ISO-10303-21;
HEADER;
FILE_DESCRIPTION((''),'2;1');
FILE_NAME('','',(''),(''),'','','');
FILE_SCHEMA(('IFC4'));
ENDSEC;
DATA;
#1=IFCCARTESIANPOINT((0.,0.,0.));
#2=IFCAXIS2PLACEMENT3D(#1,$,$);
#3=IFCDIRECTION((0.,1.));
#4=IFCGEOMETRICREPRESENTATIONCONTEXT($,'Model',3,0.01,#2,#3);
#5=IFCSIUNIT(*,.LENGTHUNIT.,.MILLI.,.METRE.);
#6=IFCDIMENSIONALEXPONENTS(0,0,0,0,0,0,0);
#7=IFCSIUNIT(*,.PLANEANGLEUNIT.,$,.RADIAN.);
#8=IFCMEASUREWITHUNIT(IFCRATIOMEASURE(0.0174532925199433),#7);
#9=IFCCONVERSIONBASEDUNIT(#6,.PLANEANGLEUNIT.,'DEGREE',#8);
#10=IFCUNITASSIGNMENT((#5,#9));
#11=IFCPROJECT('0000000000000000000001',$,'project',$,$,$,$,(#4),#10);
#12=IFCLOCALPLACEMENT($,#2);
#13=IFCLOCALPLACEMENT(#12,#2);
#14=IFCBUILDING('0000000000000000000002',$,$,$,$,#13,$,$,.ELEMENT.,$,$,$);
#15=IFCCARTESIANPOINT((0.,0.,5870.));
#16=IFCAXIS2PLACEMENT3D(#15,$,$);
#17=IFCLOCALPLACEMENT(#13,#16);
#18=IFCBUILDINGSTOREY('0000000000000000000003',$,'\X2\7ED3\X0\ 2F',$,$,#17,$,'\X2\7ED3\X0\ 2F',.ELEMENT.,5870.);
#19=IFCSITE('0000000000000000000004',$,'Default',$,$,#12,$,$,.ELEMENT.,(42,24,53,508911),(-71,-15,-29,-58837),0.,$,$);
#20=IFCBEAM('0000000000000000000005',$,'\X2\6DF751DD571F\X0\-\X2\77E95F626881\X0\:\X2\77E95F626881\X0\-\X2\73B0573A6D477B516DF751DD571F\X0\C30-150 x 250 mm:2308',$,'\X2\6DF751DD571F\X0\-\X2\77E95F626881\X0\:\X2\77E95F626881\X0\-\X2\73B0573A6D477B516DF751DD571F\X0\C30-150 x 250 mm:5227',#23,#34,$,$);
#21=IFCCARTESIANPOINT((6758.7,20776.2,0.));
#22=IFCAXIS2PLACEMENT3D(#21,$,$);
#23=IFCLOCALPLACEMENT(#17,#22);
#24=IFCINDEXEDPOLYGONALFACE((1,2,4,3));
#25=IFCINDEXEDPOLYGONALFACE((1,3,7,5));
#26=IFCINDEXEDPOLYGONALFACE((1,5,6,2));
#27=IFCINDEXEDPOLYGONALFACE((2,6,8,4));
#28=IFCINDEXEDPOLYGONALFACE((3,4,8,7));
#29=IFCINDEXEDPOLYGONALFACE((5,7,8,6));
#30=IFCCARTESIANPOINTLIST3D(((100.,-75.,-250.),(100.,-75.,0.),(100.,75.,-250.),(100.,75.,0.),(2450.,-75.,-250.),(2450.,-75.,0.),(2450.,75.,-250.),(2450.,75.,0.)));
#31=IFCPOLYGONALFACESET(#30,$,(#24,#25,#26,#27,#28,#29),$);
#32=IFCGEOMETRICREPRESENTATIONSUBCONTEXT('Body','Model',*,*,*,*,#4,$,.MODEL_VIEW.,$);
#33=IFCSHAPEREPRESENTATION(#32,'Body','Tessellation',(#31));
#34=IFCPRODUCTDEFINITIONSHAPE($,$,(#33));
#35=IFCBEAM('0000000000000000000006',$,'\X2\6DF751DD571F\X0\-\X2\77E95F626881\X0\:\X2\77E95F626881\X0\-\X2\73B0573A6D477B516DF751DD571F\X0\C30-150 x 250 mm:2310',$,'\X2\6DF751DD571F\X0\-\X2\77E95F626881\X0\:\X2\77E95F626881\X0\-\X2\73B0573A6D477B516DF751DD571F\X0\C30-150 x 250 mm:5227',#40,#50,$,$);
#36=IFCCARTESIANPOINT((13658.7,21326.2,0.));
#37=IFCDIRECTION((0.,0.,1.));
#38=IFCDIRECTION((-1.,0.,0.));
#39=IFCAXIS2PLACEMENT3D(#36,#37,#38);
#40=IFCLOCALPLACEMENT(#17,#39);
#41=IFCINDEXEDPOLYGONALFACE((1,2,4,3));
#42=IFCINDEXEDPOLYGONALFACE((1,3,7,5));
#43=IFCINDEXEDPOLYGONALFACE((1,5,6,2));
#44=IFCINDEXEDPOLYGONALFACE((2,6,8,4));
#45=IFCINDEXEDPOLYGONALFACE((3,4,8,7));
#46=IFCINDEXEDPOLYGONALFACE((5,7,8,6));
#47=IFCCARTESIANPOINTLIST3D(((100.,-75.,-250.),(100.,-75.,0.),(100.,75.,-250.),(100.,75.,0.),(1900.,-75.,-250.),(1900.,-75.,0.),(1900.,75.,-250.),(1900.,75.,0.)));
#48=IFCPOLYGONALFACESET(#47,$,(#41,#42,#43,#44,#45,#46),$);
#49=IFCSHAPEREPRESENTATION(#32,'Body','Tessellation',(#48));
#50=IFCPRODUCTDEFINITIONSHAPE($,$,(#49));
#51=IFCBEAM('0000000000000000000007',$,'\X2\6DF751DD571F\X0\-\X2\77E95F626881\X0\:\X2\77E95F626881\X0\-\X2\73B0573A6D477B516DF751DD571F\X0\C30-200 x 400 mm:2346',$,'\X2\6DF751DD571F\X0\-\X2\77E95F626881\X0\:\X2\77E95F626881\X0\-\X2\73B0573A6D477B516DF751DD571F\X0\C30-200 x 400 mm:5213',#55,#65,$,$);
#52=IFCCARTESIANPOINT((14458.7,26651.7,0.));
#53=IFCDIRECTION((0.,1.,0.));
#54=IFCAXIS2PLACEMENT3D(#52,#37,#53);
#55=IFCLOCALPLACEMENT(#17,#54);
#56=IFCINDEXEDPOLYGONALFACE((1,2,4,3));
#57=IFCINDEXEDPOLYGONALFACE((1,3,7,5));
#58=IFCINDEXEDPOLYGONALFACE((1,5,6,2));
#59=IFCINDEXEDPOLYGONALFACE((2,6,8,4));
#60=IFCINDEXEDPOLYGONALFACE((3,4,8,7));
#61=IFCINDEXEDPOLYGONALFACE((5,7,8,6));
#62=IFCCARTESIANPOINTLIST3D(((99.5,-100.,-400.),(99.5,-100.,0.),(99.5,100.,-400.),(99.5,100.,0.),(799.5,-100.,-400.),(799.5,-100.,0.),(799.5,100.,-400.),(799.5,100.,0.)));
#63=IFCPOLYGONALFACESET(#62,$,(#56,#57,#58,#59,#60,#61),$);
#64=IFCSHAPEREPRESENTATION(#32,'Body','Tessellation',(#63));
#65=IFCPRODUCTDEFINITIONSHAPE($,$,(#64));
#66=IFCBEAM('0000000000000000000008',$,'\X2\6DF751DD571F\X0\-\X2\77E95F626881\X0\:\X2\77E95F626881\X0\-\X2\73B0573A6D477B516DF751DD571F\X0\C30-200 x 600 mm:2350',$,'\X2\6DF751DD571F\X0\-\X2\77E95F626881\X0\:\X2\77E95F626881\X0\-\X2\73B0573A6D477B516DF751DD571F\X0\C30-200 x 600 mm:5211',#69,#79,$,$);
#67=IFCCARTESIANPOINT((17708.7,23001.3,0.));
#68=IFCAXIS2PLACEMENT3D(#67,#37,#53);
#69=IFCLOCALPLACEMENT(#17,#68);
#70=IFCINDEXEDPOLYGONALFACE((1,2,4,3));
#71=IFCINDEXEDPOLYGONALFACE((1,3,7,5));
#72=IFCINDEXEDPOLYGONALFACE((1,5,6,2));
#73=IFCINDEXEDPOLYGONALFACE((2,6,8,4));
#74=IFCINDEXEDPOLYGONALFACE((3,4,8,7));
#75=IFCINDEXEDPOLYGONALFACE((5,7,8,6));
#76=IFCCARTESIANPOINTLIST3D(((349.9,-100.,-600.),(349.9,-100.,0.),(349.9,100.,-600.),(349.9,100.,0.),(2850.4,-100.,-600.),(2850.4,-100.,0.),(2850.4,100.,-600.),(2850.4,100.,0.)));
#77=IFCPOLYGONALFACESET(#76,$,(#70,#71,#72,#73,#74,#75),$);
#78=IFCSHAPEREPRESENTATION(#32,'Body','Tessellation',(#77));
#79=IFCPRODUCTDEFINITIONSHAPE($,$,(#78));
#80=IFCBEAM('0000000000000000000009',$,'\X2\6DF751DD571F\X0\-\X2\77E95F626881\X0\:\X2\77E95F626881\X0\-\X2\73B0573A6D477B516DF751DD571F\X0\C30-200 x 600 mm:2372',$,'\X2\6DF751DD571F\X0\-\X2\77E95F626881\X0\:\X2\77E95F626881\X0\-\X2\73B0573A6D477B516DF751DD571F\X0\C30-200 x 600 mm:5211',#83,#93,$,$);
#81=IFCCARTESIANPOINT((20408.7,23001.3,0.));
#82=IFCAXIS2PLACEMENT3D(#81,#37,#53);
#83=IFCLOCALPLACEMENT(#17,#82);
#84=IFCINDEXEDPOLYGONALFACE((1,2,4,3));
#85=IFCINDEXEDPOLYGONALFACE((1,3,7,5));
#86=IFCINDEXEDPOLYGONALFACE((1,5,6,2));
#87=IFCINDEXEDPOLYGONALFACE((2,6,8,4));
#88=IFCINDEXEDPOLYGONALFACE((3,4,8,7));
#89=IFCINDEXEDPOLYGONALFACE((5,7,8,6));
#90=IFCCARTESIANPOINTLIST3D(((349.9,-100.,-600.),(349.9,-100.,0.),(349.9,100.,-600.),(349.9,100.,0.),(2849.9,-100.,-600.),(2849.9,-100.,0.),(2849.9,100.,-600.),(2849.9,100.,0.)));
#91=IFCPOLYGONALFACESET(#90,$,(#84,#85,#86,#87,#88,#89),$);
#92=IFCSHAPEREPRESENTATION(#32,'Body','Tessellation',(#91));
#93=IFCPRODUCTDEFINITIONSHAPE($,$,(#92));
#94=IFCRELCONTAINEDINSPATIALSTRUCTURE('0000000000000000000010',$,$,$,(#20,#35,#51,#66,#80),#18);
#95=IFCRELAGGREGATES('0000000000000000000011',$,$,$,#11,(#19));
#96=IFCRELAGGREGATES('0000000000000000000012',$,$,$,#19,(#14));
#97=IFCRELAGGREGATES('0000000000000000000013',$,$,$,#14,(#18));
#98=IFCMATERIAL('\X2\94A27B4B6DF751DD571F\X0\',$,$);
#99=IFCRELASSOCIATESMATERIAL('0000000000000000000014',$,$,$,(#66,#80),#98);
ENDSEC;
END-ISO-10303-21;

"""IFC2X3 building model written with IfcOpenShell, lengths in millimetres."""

from ifc_helpers import new_model, entity, si_unit, converted_unit, direction, frame, frame_2d, origin, place, context, subcontext, project, spatial, rectangle, extrude, material, element, save


model = new_model("IFC2X3")

# Units and contexts
model_context = context("Model", 3, precision=0.01, world=origin(), true_north=direction((0.0, 1.0)))
body_context = subcontext(model_context, "Body", "Model", "MODEL_VIEW")
ifc_project = project(units=[si_unit("LENGTHUNIT", "METRE", prefix="MILLI"), converted_unit("PLANEANGLEUNIT", "DEGREE", entity("IfcRatioMeasure", 0.0174532925199433), si_unit("PLANEANGLEUNIT", "RADIAN"), dimensions=[0, 0, 0, 0, 0, 0, 0])], contexts=[model_context])

# Site, building, storey
site_placement = place(None, origin())
site = spatial("IfcSite", under=ifc_project, at=site_placement, Name="Default", CompositionType="ELEMENT", RefLatitude=(42, 24, 53, 508911), RefLongitude=(-71, -15, -29, -58837), RefElevation=0.0)
building_placement = place(site_placement, origin())
building = spatial("IfcBuilding", under=site, at=building_placement, CompositionType="ELEMENT")
storey_placement = place(building_placement, frame((0.0, 0.0, 5870.0)))
storey = spatial("IfcBuildingStorey", under=building, at=storey_placement, Name="结 2F", LongName="结 2F", CompositionType="ELEMENT", Elevation=5870.0)

# Beams
ifc_material = material(Name="钢筋混凝土")
beam_1_placement = place(storey_placement, frame((6758.7, 20776.2, 0.0)))
element("IfcBeam", 1, at=beam_1_placement, inside=storey, Name="混凝土-矩形梁:矩形梁-现场浇筑混凝土C30-150 x 250 mm:2308", ObjectType="混凝土-矩形梁:矩形梁-现场浇筑混凝土C30-150 x 250 mm:5227", context=body_context, shape_type="SweptSolid", body=[
    extrude(rectangle(XDim=250.0, YDim=150.0, at=frame_2d((0.0, 0.0), x_axis=(1.0, 0.0))), frame((100.0, 0.0, -125.0), z_axis=(1.0, 0.0, 0.0), x_axis=(0.0, 0.0, -1.0)), (0.0, 0.0, 1.0), 2350.0),
])
beam_2_placement = place(storey_placement, frame((13658.7, 21326.2, 0.0), z_axis=(0.0, 0.0, 1.0), x_axis=(-1.0, 0.0, 0.0)))
element("IfcBeam", 2, at=beam_2_placement, inside=storey, Name="混凝土-矩形梁:矩形梁-现场浇筑混凝土C30-150 x 250 mm:2310", ObjectType="混凝土-矩形梁:矩形梁-现场浇筑混凝土C30-150 x 250 mm:5227", context=body_context, shape_type="SweptSolid", body=[
    extrude(rectangle(XDim=250.0, YDim=150.0, at=frame_2d((0.0, 0.0), x_axis=(1.0, 0.0))), frame((100.0, 0.0, -125.0), z_axis=(1.0, 0.0, 0.0), x_axis=(0.0, 0.0, -1.0)), (0.0, 0.0, 1.0), 1800.0),
])
beam_3_placement = place(storey_placement, frame((14458.7, 26651.7, 0.0), z_axis=(0.0, 0.0, 1.0), x_axis=(0.0, 1.0, 0.0)))
element("IfcBeam", 3, at=beam_3_placement, inside=storey, Name="混凝土-矩形梁:矩形梁-现场浇筑混凝土C30-200 x 400 mm:2346", ObjectType="混凝土-矩形梁:矩形梁-现场浇筑混凝土C30-200 x 400 mm:5213", context=body_context, shape_type="SweptSolid", body=[
    extrude(rectangle(XDim=400.0, YDim=200.0, at=frame_2d((0.0, 0.0), x_axis=(1.0, 0.0))), frame((99.5, 0.0, -200.0), z_axis=(1.0, 0.0, 0.0), x_axis=(0.0, 0.0, -1.0)), (0.0, 0.0, 1.0), 700.0),
])
beam_4_placement = place(storey_placement, frame((17708.7, 23001.3, 0.0), z_axis=(0.0, 0.0, 1.0), x_axis=(0.0, 1.0, 0.0)))
element("IfcBeam", 4, at=beam_4_placement, inside=storey, material=ifc_material, Name="混凝土-矩形梁:矩形梁-现场浇筑混凝土C30-200 x 600 mm:2350", ObjectType="混凝土-矩形梁:矩形梁-现场浇筑混凝土C30-200 x 600 mm:5211", context=body_context, shape_type="SweptSolid", body=[
    extrude(rectangle(XDim=600.0, YDim=200.0, at=frame_2d((0.0, 0.0), x_axis=(1.0, 0.0))), frame((349.9, 0.0, -300.0), z_axis=(1.0, 0.0, 0.0), x_axis=(0.0, 0.0, -1.0)), (0.0, 0.0, 1.0), 2500.5),
])
beam_5_placement = place(storey_placement, frame((20408.7, 23001.3, 0.0), z_axis=(0.0, 0.0, 1.0), x_axis=(0.0, 1.0, 0.0)))
element("IfcBeam", 5, at=beam_5_placement, inside=storey, material=ifc_material, Name="混凝土-矩形梁:矩形梁-现场浇筑混凝土C30-200 x 600 mm:2372", ObjectType="混凝土-矩形梁:矩形梁-现场浇筑混凝土C30-200 x 600 mm:5211", context=body_context, shape_type="SweptSolid", body=[
    extrude(rectangle(XDim=600.0, YDim=200.0, at=frame_2d((0.0, 0.0), x_axis=(1.0, 0.0))), frame((349.9, 0.0, -300.0), z_axis=(1.0, 0.0, 0.0), x_axis=(0.0, 0.0, -1.0)), (0.0, 0.0, 1.0), 2500.0),
])

save(model, "model.ifc")
